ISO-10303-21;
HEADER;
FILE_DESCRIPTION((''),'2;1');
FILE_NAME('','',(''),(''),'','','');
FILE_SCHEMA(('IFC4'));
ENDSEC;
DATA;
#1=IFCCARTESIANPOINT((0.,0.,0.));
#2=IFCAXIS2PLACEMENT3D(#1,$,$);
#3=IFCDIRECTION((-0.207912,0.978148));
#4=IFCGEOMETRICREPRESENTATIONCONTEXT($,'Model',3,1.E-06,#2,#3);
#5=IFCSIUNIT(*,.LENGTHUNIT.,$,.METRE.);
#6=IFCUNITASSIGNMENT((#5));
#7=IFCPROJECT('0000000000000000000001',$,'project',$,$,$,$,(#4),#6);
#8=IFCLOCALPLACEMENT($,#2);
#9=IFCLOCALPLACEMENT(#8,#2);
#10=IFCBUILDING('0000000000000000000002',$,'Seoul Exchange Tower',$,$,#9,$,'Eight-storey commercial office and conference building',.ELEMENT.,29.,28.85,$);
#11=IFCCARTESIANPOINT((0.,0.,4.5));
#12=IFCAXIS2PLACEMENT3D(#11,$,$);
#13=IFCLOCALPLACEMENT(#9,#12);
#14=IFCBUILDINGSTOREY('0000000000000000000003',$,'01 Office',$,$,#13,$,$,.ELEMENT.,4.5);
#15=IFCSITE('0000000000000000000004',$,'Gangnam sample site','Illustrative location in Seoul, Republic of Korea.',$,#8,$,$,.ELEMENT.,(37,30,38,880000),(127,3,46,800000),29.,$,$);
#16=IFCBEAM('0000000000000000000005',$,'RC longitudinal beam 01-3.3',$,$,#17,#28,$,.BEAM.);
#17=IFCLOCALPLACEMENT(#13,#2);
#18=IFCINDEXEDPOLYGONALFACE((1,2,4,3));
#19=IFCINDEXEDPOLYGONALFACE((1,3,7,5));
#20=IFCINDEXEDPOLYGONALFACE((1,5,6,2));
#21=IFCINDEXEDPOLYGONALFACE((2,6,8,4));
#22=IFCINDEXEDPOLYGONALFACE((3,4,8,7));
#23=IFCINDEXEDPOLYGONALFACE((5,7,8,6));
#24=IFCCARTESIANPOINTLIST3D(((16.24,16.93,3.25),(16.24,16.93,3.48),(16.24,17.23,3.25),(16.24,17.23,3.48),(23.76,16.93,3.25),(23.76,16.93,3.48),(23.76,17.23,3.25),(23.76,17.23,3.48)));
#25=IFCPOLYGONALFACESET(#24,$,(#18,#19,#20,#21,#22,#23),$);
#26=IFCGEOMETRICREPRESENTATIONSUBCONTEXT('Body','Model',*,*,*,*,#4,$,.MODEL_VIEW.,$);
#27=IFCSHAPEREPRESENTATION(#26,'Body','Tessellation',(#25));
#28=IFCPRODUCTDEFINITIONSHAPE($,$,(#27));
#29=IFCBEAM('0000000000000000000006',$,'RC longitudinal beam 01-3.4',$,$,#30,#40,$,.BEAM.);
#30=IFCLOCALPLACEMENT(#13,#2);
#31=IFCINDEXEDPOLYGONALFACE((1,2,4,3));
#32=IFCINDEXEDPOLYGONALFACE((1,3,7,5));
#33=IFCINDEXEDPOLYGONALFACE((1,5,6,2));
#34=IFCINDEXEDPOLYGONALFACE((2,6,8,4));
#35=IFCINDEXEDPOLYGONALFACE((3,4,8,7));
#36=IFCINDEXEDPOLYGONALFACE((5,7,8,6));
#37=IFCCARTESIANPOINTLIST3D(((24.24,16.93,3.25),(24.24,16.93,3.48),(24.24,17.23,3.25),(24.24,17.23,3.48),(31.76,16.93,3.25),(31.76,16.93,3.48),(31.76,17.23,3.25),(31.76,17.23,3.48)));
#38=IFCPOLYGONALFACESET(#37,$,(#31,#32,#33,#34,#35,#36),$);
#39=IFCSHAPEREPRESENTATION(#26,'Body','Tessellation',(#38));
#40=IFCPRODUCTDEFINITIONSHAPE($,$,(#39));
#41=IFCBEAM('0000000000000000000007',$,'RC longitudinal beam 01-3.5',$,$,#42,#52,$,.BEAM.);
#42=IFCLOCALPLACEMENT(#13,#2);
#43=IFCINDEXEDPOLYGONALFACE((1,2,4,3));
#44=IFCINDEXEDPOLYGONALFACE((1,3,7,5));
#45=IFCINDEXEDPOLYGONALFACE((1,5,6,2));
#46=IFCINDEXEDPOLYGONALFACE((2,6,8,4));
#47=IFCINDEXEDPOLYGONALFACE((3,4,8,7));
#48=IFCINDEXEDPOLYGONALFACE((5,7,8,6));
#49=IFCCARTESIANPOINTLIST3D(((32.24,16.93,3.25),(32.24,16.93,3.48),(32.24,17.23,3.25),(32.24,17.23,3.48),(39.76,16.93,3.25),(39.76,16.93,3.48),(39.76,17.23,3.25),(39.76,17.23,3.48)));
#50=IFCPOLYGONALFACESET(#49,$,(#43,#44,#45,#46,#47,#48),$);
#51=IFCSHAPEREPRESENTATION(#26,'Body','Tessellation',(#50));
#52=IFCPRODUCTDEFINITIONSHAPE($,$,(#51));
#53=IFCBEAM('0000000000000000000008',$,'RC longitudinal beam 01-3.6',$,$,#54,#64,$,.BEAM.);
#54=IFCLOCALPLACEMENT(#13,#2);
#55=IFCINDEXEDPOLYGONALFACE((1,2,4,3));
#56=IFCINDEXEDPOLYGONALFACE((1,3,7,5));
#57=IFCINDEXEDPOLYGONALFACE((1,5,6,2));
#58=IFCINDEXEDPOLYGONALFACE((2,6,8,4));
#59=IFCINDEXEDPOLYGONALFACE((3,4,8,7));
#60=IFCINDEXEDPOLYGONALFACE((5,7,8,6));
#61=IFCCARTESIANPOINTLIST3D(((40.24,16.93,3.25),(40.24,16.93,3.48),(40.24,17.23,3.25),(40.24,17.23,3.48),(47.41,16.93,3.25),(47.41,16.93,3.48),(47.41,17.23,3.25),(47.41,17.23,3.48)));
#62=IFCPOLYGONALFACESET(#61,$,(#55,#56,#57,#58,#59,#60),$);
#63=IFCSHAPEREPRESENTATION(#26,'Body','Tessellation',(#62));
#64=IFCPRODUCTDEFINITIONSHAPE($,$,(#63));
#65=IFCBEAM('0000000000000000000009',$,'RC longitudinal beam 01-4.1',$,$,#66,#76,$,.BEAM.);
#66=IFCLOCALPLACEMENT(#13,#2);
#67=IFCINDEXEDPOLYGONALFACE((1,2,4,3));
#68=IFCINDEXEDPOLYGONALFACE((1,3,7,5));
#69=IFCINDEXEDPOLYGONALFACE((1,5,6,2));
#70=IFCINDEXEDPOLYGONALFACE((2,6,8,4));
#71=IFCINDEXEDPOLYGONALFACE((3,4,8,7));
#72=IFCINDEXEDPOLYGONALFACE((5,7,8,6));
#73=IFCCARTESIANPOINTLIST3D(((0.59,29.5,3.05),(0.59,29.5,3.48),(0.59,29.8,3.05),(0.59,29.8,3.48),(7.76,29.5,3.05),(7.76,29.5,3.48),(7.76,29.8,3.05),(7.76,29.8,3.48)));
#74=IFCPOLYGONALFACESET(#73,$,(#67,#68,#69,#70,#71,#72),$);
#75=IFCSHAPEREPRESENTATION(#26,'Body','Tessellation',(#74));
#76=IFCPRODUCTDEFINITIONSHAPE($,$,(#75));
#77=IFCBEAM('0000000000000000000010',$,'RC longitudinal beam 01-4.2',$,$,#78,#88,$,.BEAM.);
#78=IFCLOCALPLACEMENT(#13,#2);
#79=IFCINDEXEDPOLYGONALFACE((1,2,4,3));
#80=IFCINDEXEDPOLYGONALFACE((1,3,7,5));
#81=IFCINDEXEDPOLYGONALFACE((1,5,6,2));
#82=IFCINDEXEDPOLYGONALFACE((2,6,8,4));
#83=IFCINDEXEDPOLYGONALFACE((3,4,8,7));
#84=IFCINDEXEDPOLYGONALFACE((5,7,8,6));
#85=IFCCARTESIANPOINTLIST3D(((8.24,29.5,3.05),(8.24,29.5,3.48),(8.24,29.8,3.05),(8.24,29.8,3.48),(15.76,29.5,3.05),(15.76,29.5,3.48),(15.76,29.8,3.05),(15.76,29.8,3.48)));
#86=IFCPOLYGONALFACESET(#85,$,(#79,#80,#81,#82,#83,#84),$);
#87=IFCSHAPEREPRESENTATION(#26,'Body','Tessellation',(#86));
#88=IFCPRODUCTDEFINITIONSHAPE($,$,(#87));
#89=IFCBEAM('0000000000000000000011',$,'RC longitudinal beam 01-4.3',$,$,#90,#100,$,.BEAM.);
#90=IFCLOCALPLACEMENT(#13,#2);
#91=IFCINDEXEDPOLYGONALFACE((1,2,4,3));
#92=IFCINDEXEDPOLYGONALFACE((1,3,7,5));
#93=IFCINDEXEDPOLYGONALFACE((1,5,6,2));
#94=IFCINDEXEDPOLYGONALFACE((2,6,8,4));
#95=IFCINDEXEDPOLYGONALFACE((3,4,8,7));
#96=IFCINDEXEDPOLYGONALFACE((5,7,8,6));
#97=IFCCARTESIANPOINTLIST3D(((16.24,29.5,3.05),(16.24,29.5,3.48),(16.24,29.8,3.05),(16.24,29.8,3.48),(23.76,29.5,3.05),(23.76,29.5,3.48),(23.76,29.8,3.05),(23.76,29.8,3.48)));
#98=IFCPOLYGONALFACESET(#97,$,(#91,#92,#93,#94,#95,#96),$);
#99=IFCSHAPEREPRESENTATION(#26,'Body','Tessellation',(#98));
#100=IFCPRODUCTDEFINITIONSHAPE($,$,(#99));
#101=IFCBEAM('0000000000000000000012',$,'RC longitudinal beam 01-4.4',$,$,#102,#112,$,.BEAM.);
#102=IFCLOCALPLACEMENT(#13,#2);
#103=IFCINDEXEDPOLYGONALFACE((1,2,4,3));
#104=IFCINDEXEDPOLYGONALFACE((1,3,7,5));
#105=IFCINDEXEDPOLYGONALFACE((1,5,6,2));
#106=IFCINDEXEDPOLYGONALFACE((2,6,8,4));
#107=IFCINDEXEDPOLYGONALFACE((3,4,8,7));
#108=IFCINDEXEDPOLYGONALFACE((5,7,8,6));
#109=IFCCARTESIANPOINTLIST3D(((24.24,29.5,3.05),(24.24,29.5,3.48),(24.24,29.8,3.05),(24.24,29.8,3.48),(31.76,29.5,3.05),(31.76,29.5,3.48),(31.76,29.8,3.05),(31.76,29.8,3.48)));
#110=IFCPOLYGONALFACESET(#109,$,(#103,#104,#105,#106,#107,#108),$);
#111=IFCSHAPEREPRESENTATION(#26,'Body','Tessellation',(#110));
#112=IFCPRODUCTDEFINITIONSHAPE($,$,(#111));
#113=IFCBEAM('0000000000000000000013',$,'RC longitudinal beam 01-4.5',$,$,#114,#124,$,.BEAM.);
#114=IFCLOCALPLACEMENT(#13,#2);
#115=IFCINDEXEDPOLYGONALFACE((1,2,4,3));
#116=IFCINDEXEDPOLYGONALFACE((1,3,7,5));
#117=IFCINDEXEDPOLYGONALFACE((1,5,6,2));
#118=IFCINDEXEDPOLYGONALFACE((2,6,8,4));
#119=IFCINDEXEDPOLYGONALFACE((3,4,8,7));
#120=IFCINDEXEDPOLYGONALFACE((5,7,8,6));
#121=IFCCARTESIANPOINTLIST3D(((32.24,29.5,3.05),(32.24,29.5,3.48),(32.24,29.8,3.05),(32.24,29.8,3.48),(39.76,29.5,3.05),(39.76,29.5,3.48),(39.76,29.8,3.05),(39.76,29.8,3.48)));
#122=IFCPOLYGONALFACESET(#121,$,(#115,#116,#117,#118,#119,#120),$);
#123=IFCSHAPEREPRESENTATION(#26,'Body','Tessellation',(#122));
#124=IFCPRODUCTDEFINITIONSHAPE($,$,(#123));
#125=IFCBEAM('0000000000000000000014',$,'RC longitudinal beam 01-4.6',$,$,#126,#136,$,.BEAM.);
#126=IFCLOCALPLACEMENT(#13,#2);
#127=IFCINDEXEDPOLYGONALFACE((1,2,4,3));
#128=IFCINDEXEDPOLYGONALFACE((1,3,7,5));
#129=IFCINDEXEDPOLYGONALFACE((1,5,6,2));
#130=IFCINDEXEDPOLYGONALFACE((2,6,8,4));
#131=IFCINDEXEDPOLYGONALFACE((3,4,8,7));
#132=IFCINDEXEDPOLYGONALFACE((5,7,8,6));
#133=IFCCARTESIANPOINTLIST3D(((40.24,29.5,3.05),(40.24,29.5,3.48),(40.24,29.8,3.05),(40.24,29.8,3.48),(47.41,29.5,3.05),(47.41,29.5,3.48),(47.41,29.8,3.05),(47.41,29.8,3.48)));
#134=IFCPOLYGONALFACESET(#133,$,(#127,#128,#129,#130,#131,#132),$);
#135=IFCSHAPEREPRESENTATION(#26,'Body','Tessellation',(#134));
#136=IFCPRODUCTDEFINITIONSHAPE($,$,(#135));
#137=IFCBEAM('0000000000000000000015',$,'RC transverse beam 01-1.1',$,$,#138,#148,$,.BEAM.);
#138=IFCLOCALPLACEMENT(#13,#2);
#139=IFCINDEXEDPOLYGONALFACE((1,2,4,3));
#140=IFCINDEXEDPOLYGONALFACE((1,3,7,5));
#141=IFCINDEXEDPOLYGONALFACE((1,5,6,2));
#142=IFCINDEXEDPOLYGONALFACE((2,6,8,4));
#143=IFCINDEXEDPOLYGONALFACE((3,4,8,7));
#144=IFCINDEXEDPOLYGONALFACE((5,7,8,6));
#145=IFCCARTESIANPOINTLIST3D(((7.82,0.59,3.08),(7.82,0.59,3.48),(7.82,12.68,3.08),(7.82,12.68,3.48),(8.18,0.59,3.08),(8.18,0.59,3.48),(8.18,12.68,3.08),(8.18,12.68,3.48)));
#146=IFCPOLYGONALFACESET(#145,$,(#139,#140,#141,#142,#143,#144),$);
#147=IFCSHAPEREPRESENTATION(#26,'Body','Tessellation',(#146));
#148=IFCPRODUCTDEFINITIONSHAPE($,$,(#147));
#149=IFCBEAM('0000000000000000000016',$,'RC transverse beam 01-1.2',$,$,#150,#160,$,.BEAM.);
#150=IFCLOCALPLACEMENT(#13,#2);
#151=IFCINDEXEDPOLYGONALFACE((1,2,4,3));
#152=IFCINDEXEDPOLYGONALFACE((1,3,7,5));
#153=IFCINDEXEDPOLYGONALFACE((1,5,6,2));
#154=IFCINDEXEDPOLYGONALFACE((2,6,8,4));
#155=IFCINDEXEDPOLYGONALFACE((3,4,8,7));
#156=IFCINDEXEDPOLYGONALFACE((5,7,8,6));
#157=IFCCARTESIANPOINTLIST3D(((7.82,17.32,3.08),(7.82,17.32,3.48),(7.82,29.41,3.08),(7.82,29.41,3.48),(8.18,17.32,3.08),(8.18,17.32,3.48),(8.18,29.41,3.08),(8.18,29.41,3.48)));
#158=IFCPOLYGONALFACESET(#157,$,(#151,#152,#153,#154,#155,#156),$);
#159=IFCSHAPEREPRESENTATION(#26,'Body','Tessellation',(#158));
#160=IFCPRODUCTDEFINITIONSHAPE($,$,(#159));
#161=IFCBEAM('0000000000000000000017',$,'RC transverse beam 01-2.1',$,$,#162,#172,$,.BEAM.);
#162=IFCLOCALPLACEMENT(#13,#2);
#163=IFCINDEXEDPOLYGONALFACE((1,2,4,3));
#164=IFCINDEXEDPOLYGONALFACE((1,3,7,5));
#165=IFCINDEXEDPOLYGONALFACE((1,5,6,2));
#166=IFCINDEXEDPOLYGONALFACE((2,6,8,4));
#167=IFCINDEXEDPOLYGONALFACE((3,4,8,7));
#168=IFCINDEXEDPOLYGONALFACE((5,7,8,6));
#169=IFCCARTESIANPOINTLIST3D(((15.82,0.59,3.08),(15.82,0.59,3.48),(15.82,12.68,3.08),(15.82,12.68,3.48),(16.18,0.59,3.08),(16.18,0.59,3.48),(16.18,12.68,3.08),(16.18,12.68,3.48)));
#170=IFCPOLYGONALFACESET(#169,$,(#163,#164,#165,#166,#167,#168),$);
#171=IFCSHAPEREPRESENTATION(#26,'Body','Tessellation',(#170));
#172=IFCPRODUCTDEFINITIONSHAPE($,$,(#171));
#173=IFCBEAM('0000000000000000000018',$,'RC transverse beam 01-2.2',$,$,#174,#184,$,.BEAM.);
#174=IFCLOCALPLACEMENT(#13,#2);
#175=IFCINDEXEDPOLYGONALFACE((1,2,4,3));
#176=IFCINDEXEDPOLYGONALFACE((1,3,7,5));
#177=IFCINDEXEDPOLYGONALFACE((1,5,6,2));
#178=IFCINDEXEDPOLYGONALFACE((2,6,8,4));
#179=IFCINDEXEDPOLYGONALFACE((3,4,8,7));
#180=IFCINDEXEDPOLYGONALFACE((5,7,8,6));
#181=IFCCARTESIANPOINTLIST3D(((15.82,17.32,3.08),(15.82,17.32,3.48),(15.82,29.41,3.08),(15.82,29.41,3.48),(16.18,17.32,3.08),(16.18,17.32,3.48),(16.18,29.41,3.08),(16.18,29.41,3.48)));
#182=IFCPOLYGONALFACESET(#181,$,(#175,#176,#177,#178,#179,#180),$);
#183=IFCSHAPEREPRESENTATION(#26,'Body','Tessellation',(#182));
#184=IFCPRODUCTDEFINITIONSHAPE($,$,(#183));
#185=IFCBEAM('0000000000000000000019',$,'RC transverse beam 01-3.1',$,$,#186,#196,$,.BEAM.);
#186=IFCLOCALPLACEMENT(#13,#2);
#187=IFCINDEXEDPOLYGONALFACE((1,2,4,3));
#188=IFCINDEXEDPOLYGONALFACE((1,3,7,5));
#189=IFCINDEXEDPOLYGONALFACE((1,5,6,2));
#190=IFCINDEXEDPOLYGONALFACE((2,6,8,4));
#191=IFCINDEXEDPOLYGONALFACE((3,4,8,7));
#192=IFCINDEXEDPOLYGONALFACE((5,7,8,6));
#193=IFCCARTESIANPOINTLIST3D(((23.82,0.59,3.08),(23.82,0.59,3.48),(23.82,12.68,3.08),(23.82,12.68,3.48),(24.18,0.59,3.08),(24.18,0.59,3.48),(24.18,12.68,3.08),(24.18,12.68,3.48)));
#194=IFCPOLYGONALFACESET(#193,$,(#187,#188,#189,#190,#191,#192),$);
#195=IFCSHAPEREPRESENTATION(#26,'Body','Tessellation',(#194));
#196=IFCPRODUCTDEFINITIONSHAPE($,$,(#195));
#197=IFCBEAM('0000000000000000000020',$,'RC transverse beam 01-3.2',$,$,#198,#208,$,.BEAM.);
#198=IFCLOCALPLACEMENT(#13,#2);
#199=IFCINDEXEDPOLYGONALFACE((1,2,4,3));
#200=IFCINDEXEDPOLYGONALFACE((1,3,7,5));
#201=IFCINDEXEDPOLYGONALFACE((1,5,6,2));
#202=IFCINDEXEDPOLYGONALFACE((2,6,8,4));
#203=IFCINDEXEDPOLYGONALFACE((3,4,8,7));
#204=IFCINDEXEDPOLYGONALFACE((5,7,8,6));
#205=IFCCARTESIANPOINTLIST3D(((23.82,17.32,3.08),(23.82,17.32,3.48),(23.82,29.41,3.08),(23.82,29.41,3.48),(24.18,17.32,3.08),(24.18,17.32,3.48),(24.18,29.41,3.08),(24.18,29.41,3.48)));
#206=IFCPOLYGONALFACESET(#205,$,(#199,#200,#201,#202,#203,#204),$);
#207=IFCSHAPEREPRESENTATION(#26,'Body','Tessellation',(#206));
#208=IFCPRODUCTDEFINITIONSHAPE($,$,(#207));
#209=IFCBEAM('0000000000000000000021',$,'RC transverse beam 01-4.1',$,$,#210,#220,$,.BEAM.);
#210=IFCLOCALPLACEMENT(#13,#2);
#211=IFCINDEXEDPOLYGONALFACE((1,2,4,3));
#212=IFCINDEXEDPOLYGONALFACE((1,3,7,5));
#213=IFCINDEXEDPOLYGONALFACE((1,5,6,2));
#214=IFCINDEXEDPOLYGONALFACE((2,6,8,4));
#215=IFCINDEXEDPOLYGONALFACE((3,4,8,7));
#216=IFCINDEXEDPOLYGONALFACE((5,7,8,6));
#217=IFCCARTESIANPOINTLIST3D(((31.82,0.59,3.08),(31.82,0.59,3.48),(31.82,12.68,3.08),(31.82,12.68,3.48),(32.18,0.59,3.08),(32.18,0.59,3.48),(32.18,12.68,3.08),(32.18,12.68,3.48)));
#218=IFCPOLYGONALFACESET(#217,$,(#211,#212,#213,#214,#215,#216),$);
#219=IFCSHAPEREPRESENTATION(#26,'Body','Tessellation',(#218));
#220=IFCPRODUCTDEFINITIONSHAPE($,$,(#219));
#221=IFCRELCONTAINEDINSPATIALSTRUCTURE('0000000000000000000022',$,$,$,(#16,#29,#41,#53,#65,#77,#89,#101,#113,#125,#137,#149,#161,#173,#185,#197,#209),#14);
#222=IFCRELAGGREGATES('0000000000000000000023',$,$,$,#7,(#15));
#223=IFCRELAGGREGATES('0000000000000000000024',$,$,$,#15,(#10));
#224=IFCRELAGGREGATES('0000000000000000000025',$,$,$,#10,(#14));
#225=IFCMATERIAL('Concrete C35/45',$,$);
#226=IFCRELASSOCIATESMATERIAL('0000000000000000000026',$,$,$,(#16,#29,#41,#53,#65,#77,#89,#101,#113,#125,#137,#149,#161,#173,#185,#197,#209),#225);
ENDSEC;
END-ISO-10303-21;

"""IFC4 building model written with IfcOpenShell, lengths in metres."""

from ifc_helpers import new_model, si_unit, direction, frame, frame_2d, origin, place, context, subcontext, project, spatial, rectangle, extrude, material, element, save


model = new_model("IFC4")

# Units and contexts
model_context = context("Model", 3, precision=1e-06, world=origin(), true_north=direction((-0.207912, 0.978148)))
body_context = subcontext(model_context, "Body", "Model", "MODEL_VIEW")
ifc_project = project(units=[si_unit("LENGTHUNIT", "METRE")], contexts=[model_context])

# Site, building, storey
site_placement = place(None, origin())
site = spatial("IfcSite", under=ifc_project, at=site_placement, Name="Gangnam sample site", Description="Illustrative location in Seoul, Republic of Korea.", CompositionType="ELEMENT", RefLatitude=(37, 30, 38, 880000), RefLongitude=(127, 3, 46, 800000), RefElevation=29.0)
building_placement = place(site_placement, origin())
building = spatial("IfcBuilding", under=site, at=building_placement, Name="Seoul Exchange Tower", LongName="Eight-storey commercial office and conference building", CompositionType="ELEMENT", ElevationOfRefHeight=29.0, ElevationOfTerrain=28.85)
storey_placement = place(building_placement, frame((0.0, 0.0, 4.5)))
storey = spatial("IfcBuildingStorey", under=building, at=storey_placement, Name="01 Office", CompositionType="ELEMENT", Elevation=4.5)

# Beams
ifc_material_1 = material(Name="Concrete C35/45")
placement_1 = place(storey_placement, origin())
element("IfcBeam", 1, at=placement_1, inside=storey, material=ifc_material_1, Name="RC longitudinal beam 01-3.3", PredefinedType="BEAM", context=body_context, shape_type="SweptSolid", body=[
    extrude(rectangle(XDim=7.52, YDim=0.3, at=frame_2d((3.76, 0.15))), frame((16.24, 16.93, 3.25)), (0.0, 0.0, 1.0), 0.23),
])
element("IfcBeam", 2, at=placement_1, inside=storey, material=ifc_material_1, Name="RC longitudinal beam 01-3.4", PredefinedType="BEAM", context=body_context, shape_type="SweptSolid", body=[
    extrude(rectangle(XDim=7.52, YDim=0.3, at=frame_2d((3.76, 0.15))), frame((24.24, 16.93, 3.25)), (0.0, 0.0, 1.0), 0.23),
])
element("IfcBeam", 3, at=placement_1, inside=storey, material=ifc_material_1, Name="RC longitudinal beam 01-3.5", PredefinedType="BEAM", context=body_context, shape_type="SweptSolid", body=[
    extrude(rectangle(XDim=7.52, YDim=0.3, at=frame_2d((3.76, 0.15))), frame((32.24, 16.93, 3.25)), (0.0, 0.0, 1.0), 0.23),
])
element("IfcBeam", 4, at=placement_1, inside=storey, material=ifc_material_1, Name="RC longitudinal beam 01-3.6", PredefinedType="BEAM", context=body_context, shape_type="SweptSolid", body=[
    extrude(rectangle(XDim=7.17, YDim=0.3, at=frame_2d((3.585, 0.15))), frame((40.24, 16.93, 3.25)), (0.0, 0.0, 1.0), 0.23),
])
element("IfcBeam", 5, at=placement_1, inside=storey, material=ifc_material_1, Name="RC longitudinal beam 01-4.1", PredefinedType="BEAM", context=body_context, shape_type="SweptSolid", body=[
    extrude(rectangle(XDim=7.17, YDim=0.3, at=frame_2d((3.585, 0.15))), frame((0.59, 29.5, 3.05)), (0.0, 0.0, 1.0), 0.43),
])
element("IfcBeam", 6, at=placement_1, inside=storey, material=ifc_material_1, Name="RC longitudinal beam 01-4.2", PredefinedType="BEAM", context=body_context, shape_type="SweptSolid", body=[
    extrude(rectangle(XDim=7.52, YDim=0.3, at=frame_2d((3.76, 0.15))), frame((8.24, 29.5, 3.05)), (0.0, 0.0, 1.0), 0.43),
])
element("IfcBeam", 7, at=placement_1, inside=storey, material=ifc_material_1, Name="RC longitudinal beam 01-4.3", PredefinedType="BEAM", context=body_context, shape_type="SweptSolid", body=[
    extrude(rectangle(XDim=7.52, YDim=0.3, at=frame_2d((3.76, 0.15))), frame((16.24, 29.5, 3.05)), (0.0, 0.0, 1.0), 0.43),
])
element("IfcBeam", 8, at=placement_1, inside=storey, material=ifc_material_1, Name="RC longitudinal beam 01-4.4", PredefinedType="BEAM", context=body_context, shape_type="SweptSolid", body=[
    extrude(rectangle(XDim=7.52, YDim=0.3, at=frame_2d((3.76, 0.15))), frame((24.24, 29.5, 3.05)), (0.0, 0.0, 1.0), 0.43),
])
element("IfcBeam", 9, at=placement_1, inside=storey, material=ifc_material_1, Name="RC longitudinal beam 01-4.5", PredefinedType="BEAM", context=body_context, shape_type="SweptSolid", body=[
    extrude(rectangle(XDim=7.52, YDim=0.3, at=frame_2d((3.76, 0.15))), frame((32.24, 29.5, 3.05)), (0.0, 0.0, 1.0), 0.43),
])
element("IfcBeam", 10, at=placement_1, inside=storey, material=ifc_material_1, Name="RC longitudinal beam 01-4.6", PredefinedType="BEAM", context=body_context, shape_type="SweptSolid", body=[
    extrude(rectangle(XDim=7.17, YDim=0.3, at=frame_2d((3.585, 0.15))), frame((40.24, 29.5, 3.05)), (0.0, 0.0, 1.0), 0.43),
])
element("IfcBeam", 11, at=placement_1, inside=storey, material=ifc_material_1, Name="RC transverse beam 01-1.1", PredefinedType="BEAM", context=body_context, shape_type="SweptSolid", body=[
    extrude(rectangle(XDim=0.36, YDim=12.09, at=frame_2d((0.18, 6.045))), frame((7.82, 0.59, 3.08)), (0.0, 0.0, 1.0), 0.4),
])
element("IfcBeam", 12, at=placement_1, inside=storey, material=ifc_material_1, Name="RC transverse beam 01-1.2", PredefinedType="BEAM", context=body_context, shape_type="SweptSolid", body=[
    extrude(rectangle(XDim=0.36, YDim=12.09, at=frame_2d((0.18, 6.045))), frame((7.82, 17.32, 3.08)), (0.0, 0.0, 1.0), 0.4),
])
element("IfcBeam", 13, at=placement_1, inside=storey, material=ifc_material_1, Name="RC transverse beam 01-2.1", PredefinedType="BEAM", context=body_context, shape_type="SweptSolid", body=[
    extrude(rectangle(XDim=0.36, YDim=12.09, at=frame_2d((0.18, 6.045))), frame((15.82, 0.59, 3.08)), (0.0, 0.0, 1.0), 0.4),
])
element("IfcBeam", 14, at=placement_1, inside=storey, material=ifc_material_1, Name="RC transverse beam 01-2.2", PredefinedType="BEAM", context=body_context, shape_type="SweptSolid", body=[
    extrude(rectangle(XDim=0.36, YDim=12.09, at=frame_2d((0.18, 6.045))), frame((15.82, 17.32, 3.08)), (0.0, 0.0, 1.0), 0.4),
])
element("IfcBeam", 15, at=placement_1, inside=storey, material=ifc_material_1, Name="RC transverse beam 01-3.1", PredefinedType="BEAM", context=body_context, shape_type="SweptSolid", body=[
    extrude(rectangle(XDim=0.36, YDim=12.09, at=frame_2d((0.18, 6.045))), frame((23.82, 0.59, 3.08)), (0.0, 0.0, 1.0), 0.4),
])
element("IfcBeam", 16, at=placement_1, inside=storey, material=ifc_material_1, Name="RC transverse beam 01-3.2", PredefinedType="BEAM", context=body_context, shape_type="SweptSolid", body=[
    extrude(rectangle(XDim=0.36, YDim=12.09, at=frame_2d((0.18, 6.045))), frame((23.82, 17.32, 3.08)), (0.0, 0.0, 1.0), 0.4),
])
element("IfcBeam", 17, at=placement_1, inside=storey, material=ifc_material_1, Name="RC transverse beam 01-4.1", PredefinedType="BEAM", context=body_context, shape_type="SweptSolid", body=[
    extrude(rectangle(XDim=0.36, YDim=12.09, at=frame_2d((0.18, 6.045))), frame((31.82, 0.59, 3.08)), (0.0, 0.0, 1.0), 0.4),
])

save(model, "model.ifc")
